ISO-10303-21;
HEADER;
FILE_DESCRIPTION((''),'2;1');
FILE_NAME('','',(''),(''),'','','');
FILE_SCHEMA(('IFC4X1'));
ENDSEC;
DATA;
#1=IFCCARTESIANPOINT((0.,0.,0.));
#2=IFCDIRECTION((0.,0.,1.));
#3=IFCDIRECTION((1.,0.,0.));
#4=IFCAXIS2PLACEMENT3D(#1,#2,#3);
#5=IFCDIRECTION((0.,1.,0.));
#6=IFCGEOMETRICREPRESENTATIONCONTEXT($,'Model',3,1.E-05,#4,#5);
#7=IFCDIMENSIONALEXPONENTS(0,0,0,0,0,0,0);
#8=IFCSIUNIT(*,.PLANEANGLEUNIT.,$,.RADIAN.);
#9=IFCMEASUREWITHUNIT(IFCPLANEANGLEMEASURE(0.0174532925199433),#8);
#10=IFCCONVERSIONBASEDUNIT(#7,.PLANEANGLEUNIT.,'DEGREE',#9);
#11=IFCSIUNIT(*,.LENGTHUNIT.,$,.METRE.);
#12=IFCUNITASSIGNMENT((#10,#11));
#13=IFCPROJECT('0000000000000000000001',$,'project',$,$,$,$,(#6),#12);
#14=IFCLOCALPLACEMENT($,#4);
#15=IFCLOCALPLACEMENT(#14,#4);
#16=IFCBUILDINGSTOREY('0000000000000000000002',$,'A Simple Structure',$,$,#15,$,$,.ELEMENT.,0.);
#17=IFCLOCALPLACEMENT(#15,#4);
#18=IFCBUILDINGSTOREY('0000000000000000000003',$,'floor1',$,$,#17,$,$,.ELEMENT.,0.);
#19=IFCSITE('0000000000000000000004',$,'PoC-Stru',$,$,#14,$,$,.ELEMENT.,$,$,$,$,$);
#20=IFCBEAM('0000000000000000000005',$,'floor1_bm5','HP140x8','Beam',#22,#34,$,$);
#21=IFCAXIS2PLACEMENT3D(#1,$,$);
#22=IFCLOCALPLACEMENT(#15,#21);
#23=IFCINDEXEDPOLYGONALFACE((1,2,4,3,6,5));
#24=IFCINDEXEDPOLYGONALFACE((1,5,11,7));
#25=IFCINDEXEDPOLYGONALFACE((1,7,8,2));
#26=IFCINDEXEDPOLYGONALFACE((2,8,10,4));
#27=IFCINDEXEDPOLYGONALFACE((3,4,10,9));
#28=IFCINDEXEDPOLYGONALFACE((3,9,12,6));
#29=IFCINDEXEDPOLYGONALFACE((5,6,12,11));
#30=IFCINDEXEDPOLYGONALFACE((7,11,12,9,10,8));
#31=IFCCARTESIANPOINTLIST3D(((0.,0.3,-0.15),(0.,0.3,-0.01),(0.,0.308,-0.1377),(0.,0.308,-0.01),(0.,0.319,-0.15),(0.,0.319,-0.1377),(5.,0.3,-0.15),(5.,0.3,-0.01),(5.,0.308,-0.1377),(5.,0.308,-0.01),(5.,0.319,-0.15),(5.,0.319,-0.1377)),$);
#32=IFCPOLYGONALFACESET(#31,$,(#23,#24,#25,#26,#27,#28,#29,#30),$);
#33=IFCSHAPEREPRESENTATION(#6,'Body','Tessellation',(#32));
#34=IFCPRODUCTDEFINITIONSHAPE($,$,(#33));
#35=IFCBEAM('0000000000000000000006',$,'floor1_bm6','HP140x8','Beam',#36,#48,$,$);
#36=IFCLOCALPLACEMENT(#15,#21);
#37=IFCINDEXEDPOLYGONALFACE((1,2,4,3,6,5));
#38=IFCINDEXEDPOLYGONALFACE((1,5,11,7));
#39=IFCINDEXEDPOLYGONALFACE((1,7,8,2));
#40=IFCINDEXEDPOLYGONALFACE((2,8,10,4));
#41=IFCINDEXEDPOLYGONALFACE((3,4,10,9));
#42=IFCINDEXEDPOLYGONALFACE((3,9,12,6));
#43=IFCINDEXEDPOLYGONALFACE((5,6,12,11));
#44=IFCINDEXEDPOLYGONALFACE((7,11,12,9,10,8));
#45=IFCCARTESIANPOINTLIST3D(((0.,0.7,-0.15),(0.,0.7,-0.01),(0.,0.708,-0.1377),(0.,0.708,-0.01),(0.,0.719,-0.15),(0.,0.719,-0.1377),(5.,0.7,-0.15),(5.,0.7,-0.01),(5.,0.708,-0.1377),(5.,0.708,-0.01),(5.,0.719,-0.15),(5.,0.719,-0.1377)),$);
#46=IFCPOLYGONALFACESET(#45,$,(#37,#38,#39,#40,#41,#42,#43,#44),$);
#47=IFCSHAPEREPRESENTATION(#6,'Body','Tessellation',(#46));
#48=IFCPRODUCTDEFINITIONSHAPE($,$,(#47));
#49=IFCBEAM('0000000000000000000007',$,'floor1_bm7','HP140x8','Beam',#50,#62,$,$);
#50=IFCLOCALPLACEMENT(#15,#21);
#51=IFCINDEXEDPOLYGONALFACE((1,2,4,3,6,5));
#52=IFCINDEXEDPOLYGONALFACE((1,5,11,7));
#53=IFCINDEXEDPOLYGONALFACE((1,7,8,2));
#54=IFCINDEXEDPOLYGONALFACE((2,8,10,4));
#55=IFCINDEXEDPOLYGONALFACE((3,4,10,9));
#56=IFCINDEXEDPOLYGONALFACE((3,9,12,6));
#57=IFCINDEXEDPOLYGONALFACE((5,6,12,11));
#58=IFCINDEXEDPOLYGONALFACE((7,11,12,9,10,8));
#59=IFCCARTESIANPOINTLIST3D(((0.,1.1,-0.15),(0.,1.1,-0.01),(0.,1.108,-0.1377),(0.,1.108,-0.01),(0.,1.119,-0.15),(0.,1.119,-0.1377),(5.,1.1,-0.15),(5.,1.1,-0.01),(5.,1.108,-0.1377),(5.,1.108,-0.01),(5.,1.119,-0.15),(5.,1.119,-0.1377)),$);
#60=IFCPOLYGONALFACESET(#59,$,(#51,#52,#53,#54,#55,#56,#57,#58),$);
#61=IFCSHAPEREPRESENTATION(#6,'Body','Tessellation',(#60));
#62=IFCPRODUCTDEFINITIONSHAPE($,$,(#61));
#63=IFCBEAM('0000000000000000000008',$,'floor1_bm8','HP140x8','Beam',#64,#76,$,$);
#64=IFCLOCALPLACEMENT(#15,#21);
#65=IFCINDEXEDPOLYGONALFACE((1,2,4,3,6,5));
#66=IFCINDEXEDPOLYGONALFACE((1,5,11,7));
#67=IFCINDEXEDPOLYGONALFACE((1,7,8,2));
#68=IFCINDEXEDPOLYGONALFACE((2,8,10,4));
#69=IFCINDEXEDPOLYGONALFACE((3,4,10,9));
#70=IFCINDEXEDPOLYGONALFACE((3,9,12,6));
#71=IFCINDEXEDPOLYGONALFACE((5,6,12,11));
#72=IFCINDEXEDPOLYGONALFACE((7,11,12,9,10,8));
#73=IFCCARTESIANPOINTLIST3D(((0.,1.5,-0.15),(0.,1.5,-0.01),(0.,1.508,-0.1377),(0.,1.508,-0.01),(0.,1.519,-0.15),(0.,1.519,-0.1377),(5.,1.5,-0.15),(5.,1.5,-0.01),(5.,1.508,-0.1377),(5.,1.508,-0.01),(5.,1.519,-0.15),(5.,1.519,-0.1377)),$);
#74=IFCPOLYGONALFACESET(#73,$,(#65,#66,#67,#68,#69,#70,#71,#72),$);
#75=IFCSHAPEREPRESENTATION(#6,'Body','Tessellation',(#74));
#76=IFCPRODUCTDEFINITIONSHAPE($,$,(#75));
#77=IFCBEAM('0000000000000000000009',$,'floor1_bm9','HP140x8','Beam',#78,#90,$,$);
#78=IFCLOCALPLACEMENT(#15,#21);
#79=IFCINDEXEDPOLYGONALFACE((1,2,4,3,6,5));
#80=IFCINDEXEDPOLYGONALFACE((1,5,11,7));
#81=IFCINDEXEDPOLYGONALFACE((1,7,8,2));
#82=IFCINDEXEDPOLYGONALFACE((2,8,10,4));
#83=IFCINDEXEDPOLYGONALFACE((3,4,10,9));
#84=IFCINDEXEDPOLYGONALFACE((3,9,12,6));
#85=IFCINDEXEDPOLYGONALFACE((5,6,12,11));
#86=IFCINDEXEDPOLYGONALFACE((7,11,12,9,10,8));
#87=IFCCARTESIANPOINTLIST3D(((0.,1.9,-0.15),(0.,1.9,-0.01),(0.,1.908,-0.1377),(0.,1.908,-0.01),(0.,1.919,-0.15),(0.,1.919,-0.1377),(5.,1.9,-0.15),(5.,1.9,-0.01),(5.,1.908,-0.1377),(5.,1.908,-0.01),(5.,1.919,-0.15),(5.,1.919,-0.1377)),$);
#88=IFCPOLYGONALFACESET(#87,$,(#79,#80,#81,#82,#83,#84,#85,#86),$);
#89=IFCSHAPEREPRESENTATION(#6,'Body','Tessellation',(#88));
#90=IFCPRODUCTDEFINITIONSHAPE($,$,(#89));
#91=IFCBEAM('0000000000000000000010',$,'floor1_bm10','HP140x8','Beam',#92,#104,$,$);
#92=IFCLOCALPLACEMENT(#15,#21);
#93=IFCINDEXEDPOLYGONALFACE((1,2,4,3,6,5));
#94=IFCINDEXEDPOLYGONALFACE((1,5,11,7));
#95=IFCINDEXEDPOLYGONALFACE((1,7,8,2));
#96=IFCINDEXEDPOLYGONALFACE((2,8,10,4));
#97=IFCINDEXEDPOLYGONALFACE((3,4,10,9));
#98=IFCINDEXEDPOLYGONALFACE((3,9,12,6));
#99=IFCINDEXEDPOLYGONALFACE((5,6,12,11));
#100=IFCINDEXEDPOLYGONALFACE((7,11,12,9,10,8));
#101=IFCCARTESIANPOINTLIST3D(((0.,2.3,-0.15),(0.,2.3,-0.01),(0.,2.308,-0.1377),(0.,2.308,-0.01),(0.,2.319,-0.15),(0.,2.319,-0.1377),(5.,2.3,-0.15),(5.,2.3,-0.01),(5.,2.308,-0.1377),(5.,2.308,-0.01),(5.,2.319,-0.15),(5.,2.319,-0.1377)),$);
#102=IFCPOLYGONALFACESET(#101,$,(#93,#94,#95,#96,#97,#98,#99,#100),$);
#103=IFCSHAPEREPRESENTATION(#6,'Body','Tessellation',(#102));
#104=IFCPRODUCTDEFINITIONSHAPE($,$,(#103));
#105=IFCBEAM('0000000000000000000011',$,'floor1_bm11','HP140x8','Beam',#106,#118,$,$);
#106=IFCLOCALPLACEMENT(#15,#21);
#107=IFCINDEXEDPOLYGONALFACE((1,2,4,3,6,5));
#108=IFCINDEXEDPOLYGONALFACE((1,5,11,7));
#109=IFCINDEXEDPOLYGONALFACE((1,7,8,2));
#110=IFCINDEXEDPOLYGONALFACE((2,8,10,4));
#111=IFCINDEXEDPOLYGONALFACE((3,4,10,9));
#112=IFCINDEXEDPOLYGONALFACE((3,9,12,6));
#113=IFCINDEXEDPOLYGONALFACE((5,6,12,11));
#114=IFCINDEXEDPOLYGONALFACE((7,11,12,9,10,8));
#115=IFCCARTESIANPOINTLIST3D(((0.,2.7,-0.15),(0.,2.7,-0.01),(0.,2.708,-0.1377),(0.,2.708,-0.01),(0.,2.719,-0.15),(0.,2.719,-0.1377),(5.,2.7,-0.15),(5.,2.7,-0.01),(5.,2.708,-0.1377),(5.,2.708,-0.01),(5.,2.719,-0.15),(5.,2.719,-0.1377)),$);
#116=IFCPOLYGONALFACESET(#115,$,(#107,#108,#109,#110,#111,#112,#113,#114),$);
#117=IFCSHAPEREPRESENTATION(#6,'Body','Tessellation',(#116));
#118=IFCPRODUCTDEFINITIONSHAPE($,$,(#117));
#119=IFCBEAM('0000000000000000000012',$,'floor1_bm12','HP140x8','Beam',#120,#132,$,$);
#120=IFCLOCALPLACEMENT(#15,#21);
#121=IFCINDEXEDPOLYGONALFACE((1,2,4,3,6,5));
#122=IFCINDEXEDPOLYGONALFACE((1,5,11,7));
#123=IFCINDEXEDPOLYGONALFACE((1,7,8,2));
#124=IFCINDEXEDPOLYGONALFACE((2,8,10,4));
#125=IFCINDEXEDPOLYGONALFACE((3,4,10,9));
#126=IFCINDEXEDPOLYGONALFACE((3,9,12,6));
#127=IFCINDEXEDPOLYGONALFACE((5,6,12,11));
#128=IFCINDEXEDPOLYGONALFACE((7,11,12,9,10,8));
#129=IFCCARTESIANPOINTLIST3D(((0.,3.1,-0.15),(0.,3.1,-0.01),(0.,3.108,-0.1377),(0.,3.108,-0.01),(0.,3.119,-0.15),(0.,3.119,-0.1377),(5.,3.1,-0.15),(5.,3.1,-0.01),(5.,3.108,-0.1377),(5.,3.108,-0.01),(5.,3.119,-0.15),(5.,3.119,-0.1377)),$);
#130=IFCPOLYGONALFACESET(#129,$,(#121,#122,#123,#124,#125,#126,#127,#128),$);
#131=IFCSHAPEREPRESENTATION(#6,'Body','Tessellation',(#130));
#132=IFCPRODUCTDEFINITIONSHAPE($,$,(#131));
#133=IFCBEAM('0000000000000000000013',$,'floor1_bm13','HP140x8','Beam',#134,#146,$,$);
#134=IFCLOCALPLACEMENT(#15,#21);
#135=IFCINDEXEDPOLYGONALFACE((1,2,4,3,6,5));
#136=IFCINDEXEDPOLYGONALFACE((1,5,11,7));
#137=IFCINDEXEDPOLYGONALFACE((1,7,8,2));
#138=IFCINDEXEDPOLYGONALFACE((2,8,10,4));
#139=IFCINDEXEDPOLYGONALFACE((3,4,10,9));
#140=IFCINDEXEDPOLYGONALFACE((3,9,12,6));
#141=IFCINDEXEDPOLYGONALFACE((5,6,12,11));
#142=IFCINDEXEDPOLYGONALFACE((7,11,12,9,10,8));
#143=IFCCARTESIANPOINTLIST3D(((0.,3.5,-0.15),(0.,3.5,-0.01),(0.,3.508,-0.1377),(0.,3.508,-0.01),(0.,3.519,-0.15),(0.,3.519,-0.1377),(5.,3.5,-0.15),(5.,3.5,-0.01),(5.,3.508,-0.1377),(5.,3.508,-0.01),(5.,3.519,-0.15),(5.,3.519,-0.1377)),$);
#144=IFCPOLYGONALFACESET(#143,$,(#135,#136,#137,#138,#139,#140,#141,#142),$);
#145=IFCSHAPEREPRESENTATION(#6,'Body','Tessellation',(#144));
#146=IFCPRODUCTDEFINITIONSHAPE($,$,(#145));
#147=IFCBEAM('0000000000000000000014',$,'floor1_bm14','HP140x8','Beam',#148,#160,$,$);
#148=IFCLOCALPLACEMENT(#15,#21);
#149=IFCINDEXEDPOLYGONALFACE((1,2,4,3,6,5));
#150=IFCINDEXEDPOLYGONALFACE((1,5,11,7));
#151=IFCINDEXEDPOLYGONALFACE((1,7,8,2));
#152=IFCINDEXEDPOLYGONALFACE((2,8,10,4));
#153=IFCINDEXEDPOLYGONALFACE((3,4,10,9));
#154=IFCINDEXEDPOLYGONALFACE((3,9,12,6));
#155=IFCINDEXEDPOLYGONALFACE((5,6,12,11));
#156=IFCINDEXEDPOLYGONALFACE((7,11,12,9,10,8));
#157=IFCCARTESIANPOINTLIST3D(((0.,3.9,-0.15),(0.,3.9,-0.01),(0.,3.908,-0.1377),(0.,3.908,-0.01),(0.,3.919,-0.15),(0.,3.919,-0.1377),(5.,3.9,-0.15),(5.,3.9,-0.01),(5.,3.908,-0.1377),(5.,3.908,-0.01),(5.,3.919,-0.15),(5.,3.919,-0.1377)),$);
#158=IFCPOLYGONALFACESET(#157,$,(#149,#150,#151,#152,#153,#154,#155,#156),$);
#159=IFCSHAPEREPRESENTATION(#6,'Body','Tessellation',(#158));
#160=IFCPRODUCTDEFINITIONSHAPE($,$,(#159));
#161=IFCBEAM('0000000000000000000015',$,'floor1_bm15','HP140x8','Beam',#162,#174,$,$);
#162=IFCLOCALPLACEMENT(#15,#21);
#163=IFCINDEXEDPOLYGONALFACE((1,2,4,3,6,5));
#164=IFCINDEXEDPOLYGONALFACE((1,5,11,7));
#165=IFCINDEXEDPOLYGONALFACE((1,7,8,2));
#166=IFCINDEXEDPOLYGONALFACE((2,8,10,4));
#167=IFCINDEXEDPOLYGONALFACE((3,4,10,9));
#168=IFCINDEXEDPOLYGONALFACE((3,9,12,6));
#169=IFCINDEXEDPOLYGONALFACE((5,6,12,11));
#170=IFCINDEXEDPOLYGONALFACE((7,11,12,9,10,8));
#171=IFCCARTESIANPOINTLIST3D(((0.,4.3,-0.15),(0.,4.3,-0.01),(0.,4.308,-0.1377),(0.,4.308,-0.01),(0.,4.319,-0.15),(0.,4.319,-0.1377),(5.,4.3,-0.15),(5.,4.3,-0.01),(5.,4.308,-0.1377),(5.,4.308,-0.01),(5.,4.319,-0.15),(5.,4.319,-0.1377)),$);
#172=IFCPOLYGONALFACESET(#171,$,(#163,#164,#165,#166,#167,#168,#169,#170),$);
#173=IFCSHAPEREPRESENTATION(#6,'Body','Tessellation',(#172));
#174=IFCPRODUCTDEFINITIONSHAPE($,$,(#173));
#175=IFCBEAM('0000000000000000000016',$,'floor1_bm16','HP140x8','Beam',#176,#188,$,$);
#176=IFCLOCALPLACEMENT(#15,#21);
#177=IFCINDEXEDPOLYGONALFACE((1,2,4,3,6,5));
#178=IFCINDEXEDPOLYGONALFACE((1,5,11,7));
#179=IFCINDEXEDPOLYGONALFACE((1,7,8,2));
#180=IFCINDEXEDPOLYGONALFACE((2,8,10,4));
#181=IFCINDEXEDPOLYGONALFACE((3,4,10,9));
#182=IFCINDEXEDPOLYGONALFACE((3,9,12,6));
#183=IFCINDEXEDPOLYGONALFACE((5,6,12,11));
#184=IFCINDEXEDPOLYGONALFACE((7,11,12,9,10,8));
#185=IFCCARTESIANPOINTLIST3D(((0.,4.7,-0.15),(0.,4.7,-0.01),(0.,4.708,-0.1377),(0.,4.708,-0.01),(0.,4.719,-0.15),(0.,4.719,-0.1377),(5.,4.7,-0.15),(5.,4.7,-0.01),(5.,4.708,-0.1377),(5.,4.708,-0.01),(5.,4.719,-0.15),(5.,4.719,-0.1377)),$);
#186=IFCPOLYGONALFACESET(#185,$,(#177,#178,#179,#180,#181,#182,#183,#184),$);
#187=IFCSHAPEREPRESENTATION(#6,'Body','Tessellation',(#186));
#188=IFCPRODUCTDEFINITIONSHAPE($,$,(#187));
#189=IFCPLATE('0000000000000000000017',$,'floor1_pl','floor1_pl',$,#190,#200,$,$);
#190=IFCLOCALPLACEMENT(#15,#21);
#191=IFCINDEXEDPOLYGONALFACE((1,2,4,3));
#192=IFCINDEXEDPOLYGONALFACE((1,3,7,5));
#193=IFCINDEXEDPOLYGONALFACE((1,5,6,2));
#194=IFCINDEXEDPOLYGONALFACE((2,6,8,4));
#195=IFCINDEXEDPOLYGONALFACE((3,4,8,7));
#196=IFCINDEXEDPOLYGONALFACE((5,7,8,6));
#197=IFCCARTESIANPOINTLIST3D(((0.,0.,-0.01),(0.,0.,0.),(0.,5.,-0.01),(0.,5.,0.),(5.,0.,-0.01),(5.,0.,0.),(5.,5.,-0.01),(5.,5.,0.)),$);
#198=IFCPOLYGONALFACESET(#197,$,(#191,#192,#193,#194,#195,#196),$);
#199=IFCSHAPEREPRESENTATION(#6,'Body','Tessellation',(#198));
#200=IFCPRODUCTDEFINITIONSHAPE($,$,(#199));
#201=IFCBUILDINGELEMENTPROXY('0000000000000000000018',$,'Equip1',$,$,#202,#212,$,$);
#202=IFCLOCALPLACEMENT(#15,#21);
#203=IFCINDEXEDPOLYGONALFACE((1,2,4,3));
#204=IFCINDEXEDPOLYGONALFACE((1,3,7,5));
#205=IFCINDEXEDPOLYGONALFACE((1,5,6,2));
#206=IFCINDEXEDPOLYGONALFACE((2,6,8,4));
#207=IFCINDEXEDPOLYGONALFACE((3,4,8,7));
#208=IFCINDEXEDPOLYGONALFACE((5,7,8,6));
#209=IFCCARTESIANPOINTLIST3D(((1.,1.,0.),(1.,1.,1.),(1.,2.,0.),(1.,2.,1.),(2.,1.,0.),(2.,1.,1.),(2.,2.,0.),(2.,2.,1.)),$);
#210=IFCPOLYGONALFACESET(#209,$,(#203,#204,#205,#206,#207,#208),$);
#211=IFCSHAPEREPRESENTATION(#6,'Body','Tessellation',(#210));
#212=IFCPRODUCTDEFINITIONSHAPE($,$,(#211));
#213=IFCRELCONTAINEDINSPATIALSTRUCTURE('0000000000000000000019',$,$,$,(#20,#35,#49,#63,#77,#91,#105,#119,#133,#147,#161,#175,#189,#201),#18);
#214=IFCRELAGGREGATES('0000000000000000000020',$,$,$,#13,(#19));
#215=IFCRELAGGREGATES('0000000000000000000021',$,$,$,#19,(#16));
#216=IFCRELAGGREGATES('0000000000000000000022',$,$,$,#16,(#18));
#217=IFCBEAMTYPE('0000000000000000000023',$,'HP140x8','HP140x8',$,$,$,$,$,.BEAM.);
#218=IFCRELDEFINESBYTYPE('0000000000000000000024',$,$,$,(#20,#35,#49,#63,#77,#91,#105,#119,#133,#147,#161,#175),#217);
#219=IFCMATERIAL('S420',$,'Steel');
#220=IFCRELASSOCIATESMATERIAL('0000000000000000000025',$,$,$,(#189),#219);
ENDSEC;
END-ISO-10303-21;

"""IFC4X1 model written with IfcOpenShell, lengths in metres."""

from ifc_helpers import new_model, entity, si_unit, converted_unit, direction, frame, origin, origin_with_axes, place, context, project, spatial, polyline, line, indexed_curve, outline, extrude, material, type_object, element, save


model = new_model("IFC4X1")

# Units and contexts
model_context = context("Model", 3, precision=1e-05, world=origin_with_axes(), true_north=direction((0.0, 1.0, 0.0)))
ifc_project = project(units=[converted_unit("PLANEANGLEUNIT", "DEGREE", entity("IfcPlaneAngleMeasure", 0.0174532925199433), si_unit("PLANEANGLEUNIT", "RADIAN"), dimensions=[0, 0, 0, 0, 0, 0, 0]), si_unit("LENGTHUNIT", "METRE")], contexts=[model_context])

# Site, storeys
site_placement = place(None, origin_with_axes())
site = spatial("IfcSite", under=ifc_project, at=site_placement, Name="PoC-Stru", CompositionType="ELEMENT")
storey_1_placement = place(site_placement, origin_with_axes())
storey_1 = spatial("IfcBuildingStorey", under=site, at=storey_1_placement, Name="A Simple Structure", CompositionType="ELEMENT", Elevation=0.0)
storey_2_placement = place(storey_1_placement, origin_with_axes())
storey_2 = spatial("IfcBuildingStorey", under=storey_1, at=storey_2_placement, Name="floor1", CompositionType="ELEMENT", Elevation=0.0)

# Beams
beam_type = type_object("IfcBeamType", Name="HP140x8", Description="HP140x8", PredefinedType="BEAM")
plate_placement = place(storey_2_placement, origin_with_axes())
for number, where, z_axis, x_axis, name in (
    (1, (0.0, 0.3, -0.01), (1.0, 0.0, 0.0), (0.0, 1.0, 0.0), "floor1_bm5"),
    (2, (0.0, 0.7, -0.01), (1.0, 0.0, 0.0), (0.0, 1.0, 0.0), "floor1_bm6"),
    (3, (0.0, 1.1, -0.01), (1.0, 0.0, 0.0), (0.0, 1.0, 0.0), "floor1_bm7"),
    (4, (0.0, 1.5, -0.01), (1.0, 0.0, 0.0), (0.0, 1.0, 0.0), "floor1_bm8"),
    (5, (0.0, 1.9, -0.01), (1.0, 0.0, 0.0), (0.0, 1.0, 0.0), "floor1_bm9"),
    (6, (0.0, 2.3, -0.01), (1.0, 0.0, 0.0), (0.0, 1.0, 0.0), "floor1_bm10"),
    (7, (0.0, 2.7, -0.01), (1.0, 0.0, 0.0), (0.0, 1.0, 0.0), "floor1_bm11"),
    (8, (0.0, 3.1, -0.01), (1.0, 0.0, 0.0), (0.0, 1.0, 0.0), "floor1_bm12"),
    (9, (0.0, 3.5, -0.01), (1.0, 0.0, 0.0), (0.0, 1.0, 0.0), "floor1_bm13"),
    (10, (0.0, 3.9, -0.01), (1.0, 0.0, 0.0), (0.0, 1.0, 0.0), "floor1_bm14"),
    (11, (0.0, 4.3, -0.01), (1.0, 0.0, 0.0), (0.0, 1.0, 0.0), "floor1_bm15"),
    (12, (0.0, 4.7, -0.01), (1.0, 0.0, 0.0), (0.0, 1.0, 0.0), "floor1_bm16"),
):
    element("IfcBeam", number, at=place(plate_placement, frame(where, z_axis=z_axis, x_axis=x_axis)), inside=storey_2, type_object=beam_type, Name=name, Description="HP140x8", ObjectType="Beam", context=model_context, shape_type="SweptSolid", body=[
        extrude(outline(polyline([(0.0, 0.0), (0.008, 0.0), (0.008, -0.1277), (0.019, -0.1277), (0.019, -0.14), (0.0, -0.14)])), origin(), (0.0, 0.0, 1.0), 5.0),
    ])

# Plate
ifc_material = material(Name="S420", Category="Steel")
element("IfcPlate", 13, at=plate_placement, inside=storey_2, material=ifc_material, Name="floor1_pl", Description="floor1_pl", context=model_context, shape_type="SolidModel", body=[
    extrude(outline(indexed_curve([(0.0, 5.0, 0.0), (0.0, 0.0, 0.0), (5.0, 0.0, 0.0), (5.0, 5.0, 0.0)], segments=[line(1, 2), line(2, 3), line(3, 4), line(4, 1)])), origin_with_axes(), (0.0, 0.0, -1.0), 0.01),
])

# Building element proxy
proxy_placement = place(storey_2_placement, origin_with_axes())
element("IfcBuildingElementProxy", 14, at=proxy_placement, inside=storey_2, Name="Equip1", context=model_context, shape_type="SweptSolid", body=[
    extrude(outline(polyline([(1.0, 1.0, 0.0), (1.0, 2.0, 0.0), (2.0, 2.0, 0.0), (2.0, 1.0, 0.0)])), origin_with_axes(), (0.0, 0.0, 1.0), 1.0),
])

save(model, "model.ifc")
